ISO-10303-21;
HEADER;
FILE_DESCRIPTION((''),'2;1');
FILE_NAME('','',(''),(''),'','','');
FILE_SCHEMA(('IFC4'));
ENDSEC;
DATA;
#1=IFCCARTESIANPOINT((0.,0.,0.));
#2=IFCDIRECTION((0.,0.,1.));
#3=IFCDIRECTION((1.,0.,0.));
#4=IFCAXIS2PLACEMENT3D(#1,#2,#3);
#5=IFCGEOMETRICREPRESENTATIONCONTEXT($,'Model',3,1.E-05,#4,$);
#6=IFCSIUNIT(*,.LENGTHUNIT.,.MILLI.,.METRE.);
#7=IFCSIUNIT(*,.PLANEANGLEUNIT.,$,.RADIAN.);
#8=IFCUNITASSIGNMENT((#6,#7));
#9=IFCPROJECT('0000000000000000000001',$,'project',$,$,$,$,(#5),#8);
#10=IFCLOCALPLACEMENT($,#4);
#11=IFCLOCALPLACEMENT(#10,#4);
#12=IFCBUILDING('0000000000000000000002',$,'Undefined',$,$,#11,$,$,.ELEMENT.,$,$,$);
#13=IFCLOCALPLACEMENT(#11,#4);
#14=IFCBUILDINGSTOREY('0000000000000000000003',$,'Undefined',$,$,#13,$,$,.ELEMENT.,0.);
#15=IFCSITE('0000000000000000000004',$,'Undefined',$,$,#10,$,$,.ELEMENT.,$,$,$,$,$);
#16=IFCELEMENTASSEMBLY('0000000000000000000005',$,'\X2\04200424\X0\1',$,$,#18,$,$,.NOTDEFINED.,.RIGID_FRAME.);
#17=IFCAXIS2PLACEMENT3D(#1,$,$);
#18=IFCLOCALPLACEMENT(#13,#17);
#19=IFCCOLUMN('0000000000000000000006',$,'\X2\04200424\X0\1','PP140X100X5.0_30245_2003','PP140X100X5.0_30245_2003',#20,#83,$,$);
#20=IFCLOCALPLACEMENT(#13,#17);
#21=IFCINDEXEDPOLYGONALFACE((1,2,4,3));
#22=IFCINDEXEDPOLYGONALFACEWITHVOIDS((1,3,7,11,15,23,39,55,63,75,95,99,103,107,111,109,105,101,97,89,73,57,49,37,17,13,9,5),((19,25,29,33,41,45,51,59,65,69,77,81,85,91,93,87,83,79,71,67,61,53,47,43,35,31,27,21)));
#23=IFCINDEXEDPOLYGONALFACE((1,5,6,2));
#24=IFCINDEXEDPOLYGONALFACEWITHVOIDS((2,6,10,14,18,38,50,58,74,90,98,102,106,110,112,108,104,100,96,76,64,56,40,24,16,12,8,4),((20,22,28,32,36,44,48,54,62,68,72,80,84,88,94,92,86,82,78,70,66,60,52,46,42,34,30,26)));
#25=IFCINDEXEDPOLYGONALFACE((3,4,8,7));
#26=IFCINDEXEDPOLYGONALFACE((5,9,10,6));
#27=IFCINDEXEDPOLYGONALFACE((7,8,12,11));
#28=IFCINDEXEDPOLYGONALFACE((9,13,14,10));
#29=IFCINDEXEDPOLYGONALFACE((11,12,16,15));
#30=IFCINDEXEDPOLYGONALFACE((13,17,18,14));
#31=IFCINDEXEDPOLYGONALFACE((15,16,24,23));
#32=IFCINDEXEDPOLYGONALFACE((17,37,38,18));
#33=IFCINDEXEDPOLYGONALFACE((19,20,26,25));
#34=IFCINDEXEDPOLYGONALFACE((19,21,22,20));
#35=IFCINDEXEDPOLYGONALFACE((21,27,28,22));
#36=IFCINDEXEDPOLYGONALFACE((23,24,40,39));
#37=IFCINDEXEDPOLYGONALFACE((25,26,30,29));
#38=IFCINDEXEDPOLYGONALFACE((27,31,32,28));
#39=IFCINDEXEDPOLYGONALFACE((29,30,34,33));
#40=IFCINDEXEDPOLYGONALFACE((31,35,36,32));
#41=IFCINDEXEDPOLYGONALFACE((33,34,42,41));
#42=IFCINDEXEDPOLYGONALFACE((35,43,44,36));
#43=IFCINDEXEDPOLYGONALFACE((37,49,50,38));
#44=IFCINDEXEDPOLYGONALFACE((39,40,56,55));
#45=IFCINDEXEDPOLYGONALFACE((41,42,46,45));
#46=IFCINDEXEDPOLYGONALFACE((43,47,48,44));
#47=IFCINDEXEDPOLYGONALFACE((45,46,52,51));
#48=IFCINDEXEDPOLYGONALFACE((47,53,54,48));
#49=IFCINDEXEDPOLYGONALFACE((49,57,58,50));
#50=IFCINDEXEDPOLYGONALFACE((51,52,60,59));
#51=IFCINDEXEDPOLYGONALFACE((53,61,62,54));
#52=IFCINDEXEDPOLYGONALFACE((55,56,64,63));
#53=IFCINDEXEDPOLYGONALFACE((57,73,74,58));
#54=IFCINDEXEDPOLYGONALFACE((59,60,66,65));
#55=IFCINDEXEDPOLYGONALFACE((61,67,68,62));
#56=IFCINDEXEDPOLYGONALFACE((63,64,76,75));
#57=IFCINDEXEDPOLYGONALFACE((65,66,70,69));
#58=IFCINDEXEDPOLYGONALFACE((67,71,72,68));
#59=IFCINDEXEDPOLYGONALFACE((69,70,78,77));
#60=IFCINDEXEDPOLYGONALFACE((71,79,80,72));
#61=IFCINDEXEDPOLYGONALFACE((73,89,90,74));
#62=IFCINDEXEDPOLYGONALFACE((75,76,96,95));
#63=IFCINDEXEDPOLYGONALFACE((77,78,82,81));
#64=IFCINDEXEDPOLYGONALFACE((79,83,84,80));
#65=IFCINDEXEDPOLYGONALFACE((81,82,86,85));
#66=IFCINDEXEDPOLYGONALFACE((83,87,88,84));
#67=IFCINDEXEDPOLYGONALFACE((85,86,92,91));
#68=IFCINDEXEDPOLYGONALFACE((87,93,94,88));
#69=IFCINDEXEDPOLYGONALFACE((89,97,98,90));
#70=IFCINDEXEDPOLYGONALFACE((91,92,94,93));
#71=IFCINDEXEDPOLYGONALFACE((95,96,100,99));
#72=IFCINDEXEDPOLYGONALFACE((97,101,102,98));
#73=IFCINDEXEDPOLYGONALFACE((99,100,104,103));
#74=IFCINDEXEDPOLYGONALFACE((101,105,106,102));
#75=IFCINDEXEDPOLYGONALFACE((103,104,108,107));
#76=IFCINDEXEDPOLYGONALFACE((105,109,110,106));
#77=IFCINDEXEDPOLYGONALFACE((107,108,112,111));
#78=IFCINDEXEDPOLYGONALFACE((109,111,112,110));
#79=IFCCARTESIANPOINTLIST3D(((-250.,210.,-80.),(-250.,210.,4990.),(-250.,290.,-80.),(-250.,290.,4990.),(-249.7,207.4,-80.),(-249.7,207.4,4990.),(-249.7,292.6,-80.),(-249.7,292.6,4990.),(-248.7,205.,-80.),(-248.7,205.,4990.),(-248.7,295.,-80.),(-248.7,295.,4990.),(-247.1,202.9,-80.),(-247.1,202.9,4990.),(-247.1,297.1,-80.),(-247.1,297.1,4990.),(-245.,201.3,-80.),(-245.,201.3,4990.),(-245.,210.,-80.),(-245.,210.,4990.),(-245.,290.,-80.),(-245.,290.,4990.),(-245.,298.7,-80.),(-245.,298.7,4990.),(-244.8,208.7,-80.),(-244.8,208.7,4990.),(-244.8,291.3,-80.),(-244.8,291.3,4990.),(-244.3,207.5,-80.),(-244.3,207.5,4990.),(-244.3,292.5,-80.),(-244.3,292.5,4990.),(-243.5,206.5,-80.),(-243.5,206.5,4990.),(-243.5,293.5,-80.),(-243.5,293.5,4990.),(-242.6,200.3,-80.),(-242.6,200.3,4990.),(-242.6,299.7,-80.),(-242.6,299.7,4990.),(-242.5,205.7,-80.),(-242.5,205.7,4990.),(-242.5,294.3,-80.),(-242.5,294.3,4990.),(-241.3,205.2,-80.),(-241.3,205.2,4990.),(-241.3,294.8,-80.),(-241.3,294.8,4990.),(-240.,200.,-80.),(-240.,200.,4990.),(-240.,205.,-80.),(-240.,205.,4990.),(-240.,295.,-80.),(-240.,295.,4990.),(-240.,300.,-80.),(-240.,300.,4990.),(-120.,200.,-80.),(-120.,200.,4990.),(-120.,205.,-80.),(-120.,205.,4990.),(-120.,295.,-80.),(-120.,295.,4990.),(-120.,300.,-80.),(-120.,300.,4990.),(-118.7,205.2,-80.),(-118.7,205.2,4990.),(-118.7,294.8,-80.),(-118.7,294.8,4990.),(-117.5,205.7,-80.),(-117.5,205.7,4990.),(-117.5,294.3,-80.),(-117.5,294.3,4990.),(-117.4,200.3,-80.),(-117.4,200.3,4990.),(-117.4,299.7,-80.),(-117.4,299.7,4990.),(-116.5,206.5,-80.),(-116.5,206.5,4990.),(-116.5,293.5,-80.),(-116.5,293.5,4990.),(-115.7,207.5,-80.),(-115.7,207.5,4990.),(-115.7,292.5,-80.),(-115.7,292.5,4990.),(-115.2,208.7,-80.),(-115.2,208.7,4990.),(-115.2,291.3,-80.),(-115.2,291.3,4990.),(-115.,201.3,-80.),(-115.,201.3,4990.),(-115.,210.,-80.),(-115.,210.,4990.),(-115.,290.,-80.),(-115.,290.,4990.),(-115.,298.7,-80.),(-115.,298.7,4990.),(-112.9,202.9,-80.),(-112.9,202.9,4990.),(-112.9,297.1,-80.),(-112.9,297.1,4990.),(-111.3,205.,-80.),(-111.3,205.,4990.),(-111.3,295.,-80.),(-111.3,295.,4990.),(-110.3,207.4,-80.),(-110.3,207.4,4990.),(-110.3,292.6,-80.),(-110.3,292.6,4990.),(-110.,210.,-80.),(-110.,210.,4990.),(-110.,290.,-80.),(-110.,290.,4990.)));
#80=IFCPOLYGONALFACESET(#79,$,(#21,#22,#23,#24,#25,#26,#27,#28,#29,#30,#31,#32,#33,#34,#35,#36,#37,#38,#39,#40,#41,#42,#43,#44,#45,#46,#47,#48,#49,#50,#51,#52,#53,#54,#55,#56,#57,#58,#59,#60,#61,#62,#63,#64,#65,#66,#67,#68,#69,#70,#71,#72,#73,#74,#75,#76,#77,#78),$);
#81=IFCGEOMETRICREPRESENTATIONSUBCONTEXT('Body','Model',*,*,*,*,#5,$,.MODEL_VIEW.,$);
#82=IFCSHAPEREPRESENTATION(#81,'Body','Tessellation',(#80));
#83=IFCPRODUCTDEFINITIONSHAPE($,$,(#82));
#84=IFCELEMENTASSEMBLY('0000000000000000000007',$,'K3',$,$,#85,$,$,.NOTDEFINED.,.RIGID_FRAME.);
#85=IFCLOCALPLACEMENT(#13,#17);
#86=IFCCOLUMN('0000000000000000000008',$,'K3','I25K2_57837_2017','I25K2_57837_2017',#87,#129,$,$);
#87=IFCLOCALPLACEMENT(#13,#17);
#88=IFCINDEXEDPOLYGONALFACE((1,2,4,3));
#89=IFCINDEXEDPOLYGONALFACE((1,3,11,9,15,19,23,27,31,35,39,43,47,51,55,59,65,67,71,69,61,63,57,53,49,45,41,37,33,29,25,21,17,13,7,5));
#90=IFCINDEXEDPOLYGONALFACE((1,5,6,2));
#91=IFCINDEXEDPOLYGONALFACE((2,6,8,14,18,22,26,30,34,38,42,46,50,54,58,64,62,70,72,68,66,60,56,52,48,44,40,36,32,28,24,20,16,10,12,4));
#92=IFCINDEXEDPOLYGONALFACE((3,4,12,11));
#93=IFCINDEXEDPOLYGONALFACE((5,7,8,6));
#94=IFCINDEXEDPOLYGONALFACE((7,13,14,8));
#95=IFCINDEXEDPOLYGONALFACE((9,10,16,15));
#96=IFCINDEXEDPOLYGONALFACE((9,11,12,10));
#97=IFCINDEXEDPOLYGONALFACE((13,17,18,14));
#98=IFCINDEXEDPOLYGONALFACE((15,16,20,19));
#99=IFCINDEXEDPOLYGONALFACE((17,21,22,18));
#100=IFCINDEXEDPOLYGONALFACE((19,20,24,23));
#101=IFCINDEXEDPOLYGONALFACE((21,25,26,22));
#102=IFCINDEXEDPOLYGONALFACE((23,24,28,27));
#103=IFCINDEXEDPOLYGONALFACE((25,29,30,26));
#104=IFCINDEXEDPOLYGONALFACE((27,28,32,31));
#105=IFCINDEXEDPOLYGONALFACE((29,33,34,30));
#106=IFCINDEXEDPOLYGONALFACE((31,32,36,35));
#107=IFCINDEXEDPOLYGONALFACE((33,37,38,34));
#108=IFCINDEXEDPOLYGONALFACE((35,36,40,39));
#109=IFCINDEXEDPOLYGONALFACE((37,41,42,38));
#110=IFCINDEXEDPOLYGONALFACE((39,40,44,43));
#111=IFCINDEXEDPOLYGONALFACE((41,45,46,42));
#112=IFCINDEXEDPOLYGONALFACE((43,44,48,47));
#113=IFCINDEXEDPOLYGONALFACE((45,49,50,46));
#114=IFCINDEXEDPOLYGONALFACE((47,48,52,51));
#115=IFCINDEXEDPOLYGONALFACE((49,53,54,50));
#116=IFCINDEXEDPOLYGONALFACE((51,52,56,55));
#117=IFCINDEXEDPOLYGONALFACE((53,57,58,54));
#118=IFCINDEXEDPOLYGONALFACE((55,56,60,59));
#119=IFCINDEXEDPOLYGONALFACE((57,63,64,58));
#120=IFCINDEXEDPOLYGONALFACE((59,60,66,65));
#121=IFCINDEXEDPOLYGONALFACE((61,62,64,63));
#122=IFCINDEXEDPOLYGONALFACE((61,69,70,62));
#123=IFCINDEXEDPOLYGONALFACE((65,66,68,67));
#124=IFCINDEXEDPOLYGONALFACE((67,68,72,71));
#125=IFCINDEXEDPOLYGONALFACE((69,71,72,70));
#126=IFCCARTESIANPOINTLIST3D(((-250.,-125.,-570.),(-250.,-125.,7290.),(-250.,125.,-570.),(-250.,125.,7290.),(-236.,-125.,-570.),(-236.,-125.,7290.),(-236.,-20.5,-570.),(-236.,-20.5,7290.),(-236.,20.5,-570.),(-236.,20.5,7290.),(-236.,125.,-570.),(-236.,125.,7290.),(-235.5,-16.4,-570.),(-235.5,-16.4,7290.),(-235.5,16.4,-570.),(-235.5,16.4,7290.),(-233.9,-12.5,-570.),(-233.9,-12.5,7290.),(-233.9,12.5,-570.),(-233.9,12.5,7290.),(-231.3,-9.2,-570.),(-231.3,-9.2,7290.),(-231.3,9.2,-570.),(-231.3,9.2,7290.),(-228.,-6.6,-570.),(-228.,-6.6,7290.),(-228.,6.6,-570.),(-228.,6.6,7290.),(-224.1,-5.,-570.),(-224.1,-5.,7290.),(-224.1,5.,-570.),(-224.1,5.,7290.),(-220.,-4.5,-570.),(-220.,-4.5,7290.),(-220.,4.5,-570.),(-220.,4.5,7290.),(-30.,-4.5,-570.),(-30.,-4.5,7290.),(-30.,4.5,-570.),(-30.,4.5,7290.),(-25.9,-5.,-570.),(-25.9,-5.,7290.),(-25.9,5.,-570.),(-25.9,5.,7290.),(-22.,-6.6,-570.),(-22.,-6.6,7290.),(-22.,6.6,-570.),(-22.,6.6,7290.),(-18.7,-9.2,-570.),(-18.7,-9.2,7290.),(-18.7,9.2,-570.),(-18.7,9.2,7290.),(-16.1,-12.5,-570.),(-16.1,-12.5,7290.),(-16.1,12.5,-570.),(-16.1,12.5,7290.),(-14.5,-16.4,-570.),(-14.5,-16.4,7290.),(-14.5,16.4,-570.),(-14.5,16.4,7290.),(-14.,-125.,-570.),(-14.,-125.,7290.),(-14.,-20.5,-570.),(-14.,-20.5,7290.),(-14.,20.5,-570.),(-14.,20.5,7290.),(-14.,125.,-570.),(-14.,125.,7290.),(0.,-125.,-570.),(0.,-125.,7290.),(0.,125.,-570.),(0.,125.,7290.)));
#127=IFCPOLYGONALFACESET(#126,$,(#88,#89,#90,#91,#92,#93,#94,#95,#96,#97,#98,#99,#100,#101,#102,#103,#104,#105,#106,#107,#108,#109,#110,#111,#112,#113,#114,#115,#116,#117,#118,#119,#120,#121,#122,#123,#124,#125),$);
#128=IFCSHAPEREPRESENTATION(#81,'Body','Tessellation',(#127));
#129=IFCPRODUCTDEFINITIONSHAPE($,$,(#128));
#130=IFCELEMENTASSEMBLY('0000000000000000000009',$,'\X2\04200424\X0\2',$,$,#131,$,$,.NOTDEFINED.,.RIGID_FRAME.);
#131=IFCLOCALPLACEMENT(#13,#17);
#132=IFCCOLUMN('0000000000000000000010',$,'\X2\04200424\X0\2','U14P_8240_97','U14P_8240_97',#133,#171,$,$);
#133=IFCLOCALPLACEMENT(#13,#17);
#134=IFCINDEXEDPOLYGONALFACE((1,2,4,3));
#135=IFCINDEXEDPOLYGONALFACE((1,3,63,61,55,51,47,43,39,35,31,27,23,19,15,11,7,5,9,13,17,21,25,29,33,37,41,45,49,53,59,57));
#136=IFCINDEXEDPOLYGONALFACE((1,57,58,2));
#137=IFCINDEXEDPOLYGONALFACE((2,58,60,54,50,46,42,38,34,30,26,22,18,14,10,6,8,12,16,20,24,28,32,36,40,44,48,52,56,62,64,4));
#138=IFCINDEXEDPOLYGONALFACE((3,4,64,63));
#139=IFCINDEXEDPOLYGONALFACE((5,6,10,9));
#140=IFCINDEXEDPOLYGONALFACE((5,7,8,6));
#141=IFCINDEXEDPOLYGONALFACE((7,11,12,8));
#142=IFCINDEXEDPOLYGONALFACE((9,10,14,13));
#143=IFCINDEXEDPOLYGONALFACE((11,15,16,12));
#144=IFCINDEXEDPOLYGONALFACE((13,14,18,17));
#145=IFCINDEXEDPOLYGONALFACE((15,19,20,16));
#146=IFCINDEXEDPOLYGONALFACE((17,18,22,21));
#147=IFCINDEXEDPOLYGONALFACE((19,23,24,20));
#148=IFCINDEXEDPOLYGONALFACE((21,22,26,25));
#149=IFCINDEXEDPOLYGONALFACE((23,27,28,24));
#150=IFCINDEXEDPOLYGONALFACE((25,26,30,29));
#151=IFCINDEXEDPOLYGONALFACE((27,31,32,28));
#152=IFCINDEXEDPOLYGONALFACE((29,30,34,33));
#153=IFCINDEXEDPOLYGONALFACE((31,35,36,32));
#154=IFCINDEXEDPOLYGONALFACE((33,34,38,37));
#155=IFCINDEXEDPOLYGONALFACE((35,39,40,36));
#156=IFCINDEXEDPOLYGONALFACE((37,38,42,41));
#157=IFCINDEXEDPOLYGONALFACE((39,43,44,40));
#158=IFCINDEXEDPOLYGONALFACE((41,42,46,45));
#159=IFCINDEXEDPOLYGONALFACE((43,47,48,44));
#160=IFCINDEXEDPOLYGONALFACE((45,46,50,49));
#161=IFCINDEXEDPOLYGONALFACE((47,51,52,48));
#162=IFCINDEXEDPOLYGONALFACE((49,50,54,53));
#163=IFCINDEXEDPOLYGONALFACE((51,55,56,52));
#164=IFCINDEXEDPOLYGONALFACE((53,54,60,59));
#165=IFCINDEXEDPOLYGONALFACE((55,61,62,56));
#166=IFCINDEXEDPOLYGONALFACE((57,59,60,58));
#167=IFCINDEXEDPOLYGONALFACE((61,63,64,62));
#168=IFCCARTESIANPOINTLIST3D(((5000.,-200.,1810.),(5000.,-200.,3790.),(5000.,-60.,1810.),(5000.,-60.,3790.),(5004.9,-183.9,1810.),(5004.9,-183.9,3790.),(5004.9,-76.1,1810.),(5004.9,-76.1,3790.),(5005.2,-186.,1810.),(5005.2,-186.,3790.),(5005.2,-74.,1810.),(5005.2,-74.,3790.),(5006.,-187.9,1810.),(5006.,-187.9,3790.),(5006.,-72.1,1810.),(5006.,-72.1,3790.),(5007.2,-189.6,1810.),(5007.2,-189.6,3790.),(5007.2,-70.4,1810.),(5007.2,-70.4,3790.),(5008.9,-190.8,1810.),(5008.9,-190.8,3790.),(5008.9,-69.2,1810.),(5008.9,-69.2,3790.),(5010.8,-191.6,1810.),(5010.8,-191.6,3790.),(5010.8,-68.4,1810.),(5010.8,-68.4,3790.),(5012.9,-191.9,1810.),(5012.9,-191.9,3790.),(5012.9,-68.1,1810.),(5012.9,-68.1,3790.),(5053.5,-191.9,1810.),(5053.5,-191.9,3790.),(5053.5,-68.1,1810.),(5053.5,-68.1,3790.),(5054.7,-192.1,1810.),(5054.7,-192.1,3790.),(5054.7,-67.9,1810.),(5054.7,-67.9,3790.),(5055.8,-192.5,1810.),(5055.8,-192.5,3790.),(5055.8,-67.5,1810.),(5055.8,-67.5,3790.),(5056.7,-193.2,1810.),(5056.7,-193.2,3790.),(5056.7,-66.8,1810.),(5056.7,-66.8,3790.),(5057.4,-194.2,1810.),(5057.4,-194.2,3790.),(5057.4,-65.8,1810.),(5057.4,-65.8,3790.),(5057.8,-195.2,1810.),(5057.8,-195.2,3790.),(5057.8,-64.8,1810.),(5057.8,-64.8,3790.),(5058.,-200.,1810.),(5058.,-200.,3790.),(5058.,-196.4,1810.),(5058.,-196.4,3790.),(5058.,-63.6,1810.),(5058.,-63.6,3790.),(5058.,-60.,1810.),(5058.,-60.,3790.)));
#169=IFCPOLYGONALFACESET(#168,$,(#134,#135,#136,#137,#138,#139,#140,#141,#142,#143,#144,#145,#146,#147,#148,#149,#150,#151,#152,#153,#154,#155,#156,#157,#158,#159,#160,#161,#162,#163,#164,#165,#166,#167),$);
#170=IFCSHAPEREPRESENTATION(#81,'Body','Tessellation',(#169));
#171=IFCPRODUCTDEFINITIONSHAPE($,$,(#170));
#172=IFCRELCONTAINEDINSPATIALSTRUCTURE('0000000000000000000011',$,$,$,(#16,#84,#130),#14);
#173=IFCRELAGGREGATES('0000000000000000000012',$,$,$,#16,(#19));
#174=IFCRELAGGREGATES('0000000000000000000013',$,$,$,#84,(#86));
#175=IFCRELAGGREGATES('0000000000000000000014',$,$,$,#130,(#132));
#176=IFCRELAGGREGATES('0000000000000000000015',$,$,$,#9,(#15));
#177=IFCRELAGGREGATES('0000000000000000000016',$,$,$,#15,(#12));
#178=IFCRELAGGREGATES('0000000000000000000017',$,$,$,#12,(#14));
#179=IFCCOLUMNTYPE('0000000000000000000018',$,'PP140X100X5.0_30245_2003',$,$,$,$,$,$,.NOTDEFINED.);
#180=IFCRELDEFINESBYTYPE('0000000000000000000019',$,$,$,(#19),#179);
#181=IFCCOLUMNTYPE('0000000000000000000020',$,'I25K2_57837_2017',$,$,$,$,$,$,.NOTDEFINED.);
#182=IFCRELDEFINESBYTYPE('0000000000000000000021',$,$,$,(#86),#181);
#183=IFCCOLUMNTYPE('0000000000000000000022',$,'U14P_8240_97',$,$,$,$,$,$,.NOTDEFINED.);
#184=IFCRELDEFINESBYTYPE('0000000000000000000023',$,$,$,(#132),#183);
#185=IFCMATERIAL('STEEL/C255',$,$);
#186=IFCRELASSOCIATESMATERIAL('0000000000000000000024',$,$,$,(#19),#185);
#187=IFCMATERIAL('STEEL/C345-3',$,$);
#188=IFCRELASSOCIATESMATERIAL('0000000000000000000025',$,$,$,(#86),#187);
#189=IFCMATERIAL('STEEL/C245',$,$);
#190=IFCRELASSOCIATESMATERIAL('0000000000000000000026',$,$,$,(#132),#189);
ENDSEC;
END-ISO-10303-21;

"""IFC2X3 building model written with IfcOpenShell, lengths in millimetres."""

from ifc_helpers import new_model, si_unit, frame, origin_with_axes, origin_2d_with_axis, place, context, subcontext, project, spatial, hollow_rectangle, i_section, u_section, extrude, material, type_object, element, aggregate, save


model = new_model("IFC2X3")

# Units and contexts
model_context = context("Model", 3, precision=1e-05, world=origin_with_axes())
body_context = subcontext(model_context, "Body", "Model", "MODEL_VIEW")
ifc_project = project(units=[si_unit("LENGTHUNIT", "METRE", prefix="MILLI"), si_unit("PLANEANGLEUNIT", "RADIAN")], contexts=[model_context])

# Site, building, storey
site_placement = place(None, origin_with_axes())
site = spatial("IfcSite", under=ifc_project, at=site_placement, Name="Undefined", CompositionType="ELEMENT")
building_placement = place(site_placement, origin_with_axes())
building = spatial("IfcBuilding", under=site, at=building_placement, Name="Undefined", CompositionType="ELEMENT")
storey_placement = place(building_placement, origin_with_axes())
storey = spatial("IfcBuildingStorey", under=building, at=storey_placement, Name="Undefined", CompositionType="ELEMENT", Elevation=0.0)

# Element assemblies, columns
assembly_1_placement = place(storey_placement, origin_with_axes())
assembly_1 = element("IfcElementAssembly", 1, at=assembly_1_placement, inside=storey, Name="РФ1", AssemblyPlace="NOTDEFINED", PredefinedType="RIGID_FRAME")
ifc_material_1 = material(Name="STEEL/C255")
column_type_1 = type_object("IfcColumnType", Name="PP140X100X5.0_30245_2003", PredefinedType="NOTDEFINED")
column_1_placement = place(assembly_1_placement, frame((-180.0, 250.0, -80.0), z_axis=(0.0, 0.0, 1.0), x_axis=(-1.0, 0.0, 0.0)))
column_1 = element("IfcColumn", 2, at=column_1_placement, type_object=column_type_1, material=ifc_material_1, Name="РФ1", Description="PP140X100X5.0_30245_2003", ObjectType="PP140X100X5.0_30245_2003", context=body_context, shape_type="SweptSolid", body=[
    extrude(hollow_rectangle(XDim=100.0, YDim=140.0, WallThickness=5.0, InnerFilletRadius=5.0, OuterFilletRadius=10.0, at=origin_2d_with_axis()), frame((0.0, 0.0, 5070.0), z_axis=(0.0, 0.0, -1.0), x_axis=(0.0, 1.0, 0.0)), (0.0, 0.0, 1.0), 5070.0),
])
aggregate(assembly_1, [column_1])
assembly_2_placement = place(storey_placement, origin_with_axes())
assembly_2 = element("IfcElementAssembly", 3, at=assembly_2_placement, inside=storey, Name="K3", AssemblyPlace="NOTDEFINED", PredefinedType="RIGID_FRAME")
ifc_material_2 = material(Name="STEEL/C345-3")
column_type_2 = type_object("IfcColumnType", Name="I25K2_57837_2017", PredefinedType="NOTDEFINED")
column_2_placement = place(assembly_2_placement, frame((-125.0, 0.0, -570.0), z_axis=(0.0, 0.0, 1.0), x_axis=(-1.0, 0.0, 0.0)))
column_2 = element("IfcColumn", 4, at=column_2_placement, type_object=column_type_2, material=ifc_material_2, Name="K3", Description="I25K2_57837_2017", ObjectType="I25K2_57837_2017", context=body_context, shape_type="SweptSolid", body=[
    extrude(i_section(OverallWidth=250.0, OverallDepth=250.0, WebThickness=9.0, FlangeThickness=14.0, FilletRadius=16.0, at=origin_2d_with_axis()), frame((0.0, 0.0, 7860.0), z_axis=(0.0, 0.0, -1.0), x_axis=(0.0, 1.0, 0.0)), (0.0, 0.0, 1.0), 7860.0),
])
aggregate(assembly_2, [column_2])
assembly_3_placement = place(storey_placement, origin_with_axes())
assembly_3 = element("IfcElementAssembly", 5, at=assembly_3_placement, inside=storey, Name="РФ2", AssemblyPlace="NOTDEFINED", PredefinedType="RIGID_FRAME")
ifc_material_3 = material(Name="STEEL/C245")
column_type_3 = type_object("IfcColumnType", Name="U14P_8240_97", PredefinedType="NOTDEFINED")
column_3_placement = place(assembly_3_placement, frame((5029.0, -130.0, 1810.0), z_axis=(0.0, 0.0, 1.0), x_axis=(0.0, -1.0, 0.0)))
column_3 = element("IfcColumn", 6, at=column_3_placement, type_object=column_type_3, material=ifc_material_3, Name="РФ2", Description="U14P_8240_97", ObjectType="U14P_8240_97", context=body_context, shape_type="SweptSolid", body=[
    extrude(u_section(Depth=140.0, FlangeWidth=58.0, WebThickness=4.9, FlangeThickness=8.1, FilletRadius=8.0, EdgeRadius=4.5, at=origin_2d_with_axis()), frame((0.0, 0.0, 1980.0), z_axis=(0.0, 0.0, -1.0), x_axis=(0.0, 1.0, 0.0)), (0.0, 0.0, 1.0), 1980.0),
])
aggregate(assembly_3, [column_3])

save(model, "model.ifc")
